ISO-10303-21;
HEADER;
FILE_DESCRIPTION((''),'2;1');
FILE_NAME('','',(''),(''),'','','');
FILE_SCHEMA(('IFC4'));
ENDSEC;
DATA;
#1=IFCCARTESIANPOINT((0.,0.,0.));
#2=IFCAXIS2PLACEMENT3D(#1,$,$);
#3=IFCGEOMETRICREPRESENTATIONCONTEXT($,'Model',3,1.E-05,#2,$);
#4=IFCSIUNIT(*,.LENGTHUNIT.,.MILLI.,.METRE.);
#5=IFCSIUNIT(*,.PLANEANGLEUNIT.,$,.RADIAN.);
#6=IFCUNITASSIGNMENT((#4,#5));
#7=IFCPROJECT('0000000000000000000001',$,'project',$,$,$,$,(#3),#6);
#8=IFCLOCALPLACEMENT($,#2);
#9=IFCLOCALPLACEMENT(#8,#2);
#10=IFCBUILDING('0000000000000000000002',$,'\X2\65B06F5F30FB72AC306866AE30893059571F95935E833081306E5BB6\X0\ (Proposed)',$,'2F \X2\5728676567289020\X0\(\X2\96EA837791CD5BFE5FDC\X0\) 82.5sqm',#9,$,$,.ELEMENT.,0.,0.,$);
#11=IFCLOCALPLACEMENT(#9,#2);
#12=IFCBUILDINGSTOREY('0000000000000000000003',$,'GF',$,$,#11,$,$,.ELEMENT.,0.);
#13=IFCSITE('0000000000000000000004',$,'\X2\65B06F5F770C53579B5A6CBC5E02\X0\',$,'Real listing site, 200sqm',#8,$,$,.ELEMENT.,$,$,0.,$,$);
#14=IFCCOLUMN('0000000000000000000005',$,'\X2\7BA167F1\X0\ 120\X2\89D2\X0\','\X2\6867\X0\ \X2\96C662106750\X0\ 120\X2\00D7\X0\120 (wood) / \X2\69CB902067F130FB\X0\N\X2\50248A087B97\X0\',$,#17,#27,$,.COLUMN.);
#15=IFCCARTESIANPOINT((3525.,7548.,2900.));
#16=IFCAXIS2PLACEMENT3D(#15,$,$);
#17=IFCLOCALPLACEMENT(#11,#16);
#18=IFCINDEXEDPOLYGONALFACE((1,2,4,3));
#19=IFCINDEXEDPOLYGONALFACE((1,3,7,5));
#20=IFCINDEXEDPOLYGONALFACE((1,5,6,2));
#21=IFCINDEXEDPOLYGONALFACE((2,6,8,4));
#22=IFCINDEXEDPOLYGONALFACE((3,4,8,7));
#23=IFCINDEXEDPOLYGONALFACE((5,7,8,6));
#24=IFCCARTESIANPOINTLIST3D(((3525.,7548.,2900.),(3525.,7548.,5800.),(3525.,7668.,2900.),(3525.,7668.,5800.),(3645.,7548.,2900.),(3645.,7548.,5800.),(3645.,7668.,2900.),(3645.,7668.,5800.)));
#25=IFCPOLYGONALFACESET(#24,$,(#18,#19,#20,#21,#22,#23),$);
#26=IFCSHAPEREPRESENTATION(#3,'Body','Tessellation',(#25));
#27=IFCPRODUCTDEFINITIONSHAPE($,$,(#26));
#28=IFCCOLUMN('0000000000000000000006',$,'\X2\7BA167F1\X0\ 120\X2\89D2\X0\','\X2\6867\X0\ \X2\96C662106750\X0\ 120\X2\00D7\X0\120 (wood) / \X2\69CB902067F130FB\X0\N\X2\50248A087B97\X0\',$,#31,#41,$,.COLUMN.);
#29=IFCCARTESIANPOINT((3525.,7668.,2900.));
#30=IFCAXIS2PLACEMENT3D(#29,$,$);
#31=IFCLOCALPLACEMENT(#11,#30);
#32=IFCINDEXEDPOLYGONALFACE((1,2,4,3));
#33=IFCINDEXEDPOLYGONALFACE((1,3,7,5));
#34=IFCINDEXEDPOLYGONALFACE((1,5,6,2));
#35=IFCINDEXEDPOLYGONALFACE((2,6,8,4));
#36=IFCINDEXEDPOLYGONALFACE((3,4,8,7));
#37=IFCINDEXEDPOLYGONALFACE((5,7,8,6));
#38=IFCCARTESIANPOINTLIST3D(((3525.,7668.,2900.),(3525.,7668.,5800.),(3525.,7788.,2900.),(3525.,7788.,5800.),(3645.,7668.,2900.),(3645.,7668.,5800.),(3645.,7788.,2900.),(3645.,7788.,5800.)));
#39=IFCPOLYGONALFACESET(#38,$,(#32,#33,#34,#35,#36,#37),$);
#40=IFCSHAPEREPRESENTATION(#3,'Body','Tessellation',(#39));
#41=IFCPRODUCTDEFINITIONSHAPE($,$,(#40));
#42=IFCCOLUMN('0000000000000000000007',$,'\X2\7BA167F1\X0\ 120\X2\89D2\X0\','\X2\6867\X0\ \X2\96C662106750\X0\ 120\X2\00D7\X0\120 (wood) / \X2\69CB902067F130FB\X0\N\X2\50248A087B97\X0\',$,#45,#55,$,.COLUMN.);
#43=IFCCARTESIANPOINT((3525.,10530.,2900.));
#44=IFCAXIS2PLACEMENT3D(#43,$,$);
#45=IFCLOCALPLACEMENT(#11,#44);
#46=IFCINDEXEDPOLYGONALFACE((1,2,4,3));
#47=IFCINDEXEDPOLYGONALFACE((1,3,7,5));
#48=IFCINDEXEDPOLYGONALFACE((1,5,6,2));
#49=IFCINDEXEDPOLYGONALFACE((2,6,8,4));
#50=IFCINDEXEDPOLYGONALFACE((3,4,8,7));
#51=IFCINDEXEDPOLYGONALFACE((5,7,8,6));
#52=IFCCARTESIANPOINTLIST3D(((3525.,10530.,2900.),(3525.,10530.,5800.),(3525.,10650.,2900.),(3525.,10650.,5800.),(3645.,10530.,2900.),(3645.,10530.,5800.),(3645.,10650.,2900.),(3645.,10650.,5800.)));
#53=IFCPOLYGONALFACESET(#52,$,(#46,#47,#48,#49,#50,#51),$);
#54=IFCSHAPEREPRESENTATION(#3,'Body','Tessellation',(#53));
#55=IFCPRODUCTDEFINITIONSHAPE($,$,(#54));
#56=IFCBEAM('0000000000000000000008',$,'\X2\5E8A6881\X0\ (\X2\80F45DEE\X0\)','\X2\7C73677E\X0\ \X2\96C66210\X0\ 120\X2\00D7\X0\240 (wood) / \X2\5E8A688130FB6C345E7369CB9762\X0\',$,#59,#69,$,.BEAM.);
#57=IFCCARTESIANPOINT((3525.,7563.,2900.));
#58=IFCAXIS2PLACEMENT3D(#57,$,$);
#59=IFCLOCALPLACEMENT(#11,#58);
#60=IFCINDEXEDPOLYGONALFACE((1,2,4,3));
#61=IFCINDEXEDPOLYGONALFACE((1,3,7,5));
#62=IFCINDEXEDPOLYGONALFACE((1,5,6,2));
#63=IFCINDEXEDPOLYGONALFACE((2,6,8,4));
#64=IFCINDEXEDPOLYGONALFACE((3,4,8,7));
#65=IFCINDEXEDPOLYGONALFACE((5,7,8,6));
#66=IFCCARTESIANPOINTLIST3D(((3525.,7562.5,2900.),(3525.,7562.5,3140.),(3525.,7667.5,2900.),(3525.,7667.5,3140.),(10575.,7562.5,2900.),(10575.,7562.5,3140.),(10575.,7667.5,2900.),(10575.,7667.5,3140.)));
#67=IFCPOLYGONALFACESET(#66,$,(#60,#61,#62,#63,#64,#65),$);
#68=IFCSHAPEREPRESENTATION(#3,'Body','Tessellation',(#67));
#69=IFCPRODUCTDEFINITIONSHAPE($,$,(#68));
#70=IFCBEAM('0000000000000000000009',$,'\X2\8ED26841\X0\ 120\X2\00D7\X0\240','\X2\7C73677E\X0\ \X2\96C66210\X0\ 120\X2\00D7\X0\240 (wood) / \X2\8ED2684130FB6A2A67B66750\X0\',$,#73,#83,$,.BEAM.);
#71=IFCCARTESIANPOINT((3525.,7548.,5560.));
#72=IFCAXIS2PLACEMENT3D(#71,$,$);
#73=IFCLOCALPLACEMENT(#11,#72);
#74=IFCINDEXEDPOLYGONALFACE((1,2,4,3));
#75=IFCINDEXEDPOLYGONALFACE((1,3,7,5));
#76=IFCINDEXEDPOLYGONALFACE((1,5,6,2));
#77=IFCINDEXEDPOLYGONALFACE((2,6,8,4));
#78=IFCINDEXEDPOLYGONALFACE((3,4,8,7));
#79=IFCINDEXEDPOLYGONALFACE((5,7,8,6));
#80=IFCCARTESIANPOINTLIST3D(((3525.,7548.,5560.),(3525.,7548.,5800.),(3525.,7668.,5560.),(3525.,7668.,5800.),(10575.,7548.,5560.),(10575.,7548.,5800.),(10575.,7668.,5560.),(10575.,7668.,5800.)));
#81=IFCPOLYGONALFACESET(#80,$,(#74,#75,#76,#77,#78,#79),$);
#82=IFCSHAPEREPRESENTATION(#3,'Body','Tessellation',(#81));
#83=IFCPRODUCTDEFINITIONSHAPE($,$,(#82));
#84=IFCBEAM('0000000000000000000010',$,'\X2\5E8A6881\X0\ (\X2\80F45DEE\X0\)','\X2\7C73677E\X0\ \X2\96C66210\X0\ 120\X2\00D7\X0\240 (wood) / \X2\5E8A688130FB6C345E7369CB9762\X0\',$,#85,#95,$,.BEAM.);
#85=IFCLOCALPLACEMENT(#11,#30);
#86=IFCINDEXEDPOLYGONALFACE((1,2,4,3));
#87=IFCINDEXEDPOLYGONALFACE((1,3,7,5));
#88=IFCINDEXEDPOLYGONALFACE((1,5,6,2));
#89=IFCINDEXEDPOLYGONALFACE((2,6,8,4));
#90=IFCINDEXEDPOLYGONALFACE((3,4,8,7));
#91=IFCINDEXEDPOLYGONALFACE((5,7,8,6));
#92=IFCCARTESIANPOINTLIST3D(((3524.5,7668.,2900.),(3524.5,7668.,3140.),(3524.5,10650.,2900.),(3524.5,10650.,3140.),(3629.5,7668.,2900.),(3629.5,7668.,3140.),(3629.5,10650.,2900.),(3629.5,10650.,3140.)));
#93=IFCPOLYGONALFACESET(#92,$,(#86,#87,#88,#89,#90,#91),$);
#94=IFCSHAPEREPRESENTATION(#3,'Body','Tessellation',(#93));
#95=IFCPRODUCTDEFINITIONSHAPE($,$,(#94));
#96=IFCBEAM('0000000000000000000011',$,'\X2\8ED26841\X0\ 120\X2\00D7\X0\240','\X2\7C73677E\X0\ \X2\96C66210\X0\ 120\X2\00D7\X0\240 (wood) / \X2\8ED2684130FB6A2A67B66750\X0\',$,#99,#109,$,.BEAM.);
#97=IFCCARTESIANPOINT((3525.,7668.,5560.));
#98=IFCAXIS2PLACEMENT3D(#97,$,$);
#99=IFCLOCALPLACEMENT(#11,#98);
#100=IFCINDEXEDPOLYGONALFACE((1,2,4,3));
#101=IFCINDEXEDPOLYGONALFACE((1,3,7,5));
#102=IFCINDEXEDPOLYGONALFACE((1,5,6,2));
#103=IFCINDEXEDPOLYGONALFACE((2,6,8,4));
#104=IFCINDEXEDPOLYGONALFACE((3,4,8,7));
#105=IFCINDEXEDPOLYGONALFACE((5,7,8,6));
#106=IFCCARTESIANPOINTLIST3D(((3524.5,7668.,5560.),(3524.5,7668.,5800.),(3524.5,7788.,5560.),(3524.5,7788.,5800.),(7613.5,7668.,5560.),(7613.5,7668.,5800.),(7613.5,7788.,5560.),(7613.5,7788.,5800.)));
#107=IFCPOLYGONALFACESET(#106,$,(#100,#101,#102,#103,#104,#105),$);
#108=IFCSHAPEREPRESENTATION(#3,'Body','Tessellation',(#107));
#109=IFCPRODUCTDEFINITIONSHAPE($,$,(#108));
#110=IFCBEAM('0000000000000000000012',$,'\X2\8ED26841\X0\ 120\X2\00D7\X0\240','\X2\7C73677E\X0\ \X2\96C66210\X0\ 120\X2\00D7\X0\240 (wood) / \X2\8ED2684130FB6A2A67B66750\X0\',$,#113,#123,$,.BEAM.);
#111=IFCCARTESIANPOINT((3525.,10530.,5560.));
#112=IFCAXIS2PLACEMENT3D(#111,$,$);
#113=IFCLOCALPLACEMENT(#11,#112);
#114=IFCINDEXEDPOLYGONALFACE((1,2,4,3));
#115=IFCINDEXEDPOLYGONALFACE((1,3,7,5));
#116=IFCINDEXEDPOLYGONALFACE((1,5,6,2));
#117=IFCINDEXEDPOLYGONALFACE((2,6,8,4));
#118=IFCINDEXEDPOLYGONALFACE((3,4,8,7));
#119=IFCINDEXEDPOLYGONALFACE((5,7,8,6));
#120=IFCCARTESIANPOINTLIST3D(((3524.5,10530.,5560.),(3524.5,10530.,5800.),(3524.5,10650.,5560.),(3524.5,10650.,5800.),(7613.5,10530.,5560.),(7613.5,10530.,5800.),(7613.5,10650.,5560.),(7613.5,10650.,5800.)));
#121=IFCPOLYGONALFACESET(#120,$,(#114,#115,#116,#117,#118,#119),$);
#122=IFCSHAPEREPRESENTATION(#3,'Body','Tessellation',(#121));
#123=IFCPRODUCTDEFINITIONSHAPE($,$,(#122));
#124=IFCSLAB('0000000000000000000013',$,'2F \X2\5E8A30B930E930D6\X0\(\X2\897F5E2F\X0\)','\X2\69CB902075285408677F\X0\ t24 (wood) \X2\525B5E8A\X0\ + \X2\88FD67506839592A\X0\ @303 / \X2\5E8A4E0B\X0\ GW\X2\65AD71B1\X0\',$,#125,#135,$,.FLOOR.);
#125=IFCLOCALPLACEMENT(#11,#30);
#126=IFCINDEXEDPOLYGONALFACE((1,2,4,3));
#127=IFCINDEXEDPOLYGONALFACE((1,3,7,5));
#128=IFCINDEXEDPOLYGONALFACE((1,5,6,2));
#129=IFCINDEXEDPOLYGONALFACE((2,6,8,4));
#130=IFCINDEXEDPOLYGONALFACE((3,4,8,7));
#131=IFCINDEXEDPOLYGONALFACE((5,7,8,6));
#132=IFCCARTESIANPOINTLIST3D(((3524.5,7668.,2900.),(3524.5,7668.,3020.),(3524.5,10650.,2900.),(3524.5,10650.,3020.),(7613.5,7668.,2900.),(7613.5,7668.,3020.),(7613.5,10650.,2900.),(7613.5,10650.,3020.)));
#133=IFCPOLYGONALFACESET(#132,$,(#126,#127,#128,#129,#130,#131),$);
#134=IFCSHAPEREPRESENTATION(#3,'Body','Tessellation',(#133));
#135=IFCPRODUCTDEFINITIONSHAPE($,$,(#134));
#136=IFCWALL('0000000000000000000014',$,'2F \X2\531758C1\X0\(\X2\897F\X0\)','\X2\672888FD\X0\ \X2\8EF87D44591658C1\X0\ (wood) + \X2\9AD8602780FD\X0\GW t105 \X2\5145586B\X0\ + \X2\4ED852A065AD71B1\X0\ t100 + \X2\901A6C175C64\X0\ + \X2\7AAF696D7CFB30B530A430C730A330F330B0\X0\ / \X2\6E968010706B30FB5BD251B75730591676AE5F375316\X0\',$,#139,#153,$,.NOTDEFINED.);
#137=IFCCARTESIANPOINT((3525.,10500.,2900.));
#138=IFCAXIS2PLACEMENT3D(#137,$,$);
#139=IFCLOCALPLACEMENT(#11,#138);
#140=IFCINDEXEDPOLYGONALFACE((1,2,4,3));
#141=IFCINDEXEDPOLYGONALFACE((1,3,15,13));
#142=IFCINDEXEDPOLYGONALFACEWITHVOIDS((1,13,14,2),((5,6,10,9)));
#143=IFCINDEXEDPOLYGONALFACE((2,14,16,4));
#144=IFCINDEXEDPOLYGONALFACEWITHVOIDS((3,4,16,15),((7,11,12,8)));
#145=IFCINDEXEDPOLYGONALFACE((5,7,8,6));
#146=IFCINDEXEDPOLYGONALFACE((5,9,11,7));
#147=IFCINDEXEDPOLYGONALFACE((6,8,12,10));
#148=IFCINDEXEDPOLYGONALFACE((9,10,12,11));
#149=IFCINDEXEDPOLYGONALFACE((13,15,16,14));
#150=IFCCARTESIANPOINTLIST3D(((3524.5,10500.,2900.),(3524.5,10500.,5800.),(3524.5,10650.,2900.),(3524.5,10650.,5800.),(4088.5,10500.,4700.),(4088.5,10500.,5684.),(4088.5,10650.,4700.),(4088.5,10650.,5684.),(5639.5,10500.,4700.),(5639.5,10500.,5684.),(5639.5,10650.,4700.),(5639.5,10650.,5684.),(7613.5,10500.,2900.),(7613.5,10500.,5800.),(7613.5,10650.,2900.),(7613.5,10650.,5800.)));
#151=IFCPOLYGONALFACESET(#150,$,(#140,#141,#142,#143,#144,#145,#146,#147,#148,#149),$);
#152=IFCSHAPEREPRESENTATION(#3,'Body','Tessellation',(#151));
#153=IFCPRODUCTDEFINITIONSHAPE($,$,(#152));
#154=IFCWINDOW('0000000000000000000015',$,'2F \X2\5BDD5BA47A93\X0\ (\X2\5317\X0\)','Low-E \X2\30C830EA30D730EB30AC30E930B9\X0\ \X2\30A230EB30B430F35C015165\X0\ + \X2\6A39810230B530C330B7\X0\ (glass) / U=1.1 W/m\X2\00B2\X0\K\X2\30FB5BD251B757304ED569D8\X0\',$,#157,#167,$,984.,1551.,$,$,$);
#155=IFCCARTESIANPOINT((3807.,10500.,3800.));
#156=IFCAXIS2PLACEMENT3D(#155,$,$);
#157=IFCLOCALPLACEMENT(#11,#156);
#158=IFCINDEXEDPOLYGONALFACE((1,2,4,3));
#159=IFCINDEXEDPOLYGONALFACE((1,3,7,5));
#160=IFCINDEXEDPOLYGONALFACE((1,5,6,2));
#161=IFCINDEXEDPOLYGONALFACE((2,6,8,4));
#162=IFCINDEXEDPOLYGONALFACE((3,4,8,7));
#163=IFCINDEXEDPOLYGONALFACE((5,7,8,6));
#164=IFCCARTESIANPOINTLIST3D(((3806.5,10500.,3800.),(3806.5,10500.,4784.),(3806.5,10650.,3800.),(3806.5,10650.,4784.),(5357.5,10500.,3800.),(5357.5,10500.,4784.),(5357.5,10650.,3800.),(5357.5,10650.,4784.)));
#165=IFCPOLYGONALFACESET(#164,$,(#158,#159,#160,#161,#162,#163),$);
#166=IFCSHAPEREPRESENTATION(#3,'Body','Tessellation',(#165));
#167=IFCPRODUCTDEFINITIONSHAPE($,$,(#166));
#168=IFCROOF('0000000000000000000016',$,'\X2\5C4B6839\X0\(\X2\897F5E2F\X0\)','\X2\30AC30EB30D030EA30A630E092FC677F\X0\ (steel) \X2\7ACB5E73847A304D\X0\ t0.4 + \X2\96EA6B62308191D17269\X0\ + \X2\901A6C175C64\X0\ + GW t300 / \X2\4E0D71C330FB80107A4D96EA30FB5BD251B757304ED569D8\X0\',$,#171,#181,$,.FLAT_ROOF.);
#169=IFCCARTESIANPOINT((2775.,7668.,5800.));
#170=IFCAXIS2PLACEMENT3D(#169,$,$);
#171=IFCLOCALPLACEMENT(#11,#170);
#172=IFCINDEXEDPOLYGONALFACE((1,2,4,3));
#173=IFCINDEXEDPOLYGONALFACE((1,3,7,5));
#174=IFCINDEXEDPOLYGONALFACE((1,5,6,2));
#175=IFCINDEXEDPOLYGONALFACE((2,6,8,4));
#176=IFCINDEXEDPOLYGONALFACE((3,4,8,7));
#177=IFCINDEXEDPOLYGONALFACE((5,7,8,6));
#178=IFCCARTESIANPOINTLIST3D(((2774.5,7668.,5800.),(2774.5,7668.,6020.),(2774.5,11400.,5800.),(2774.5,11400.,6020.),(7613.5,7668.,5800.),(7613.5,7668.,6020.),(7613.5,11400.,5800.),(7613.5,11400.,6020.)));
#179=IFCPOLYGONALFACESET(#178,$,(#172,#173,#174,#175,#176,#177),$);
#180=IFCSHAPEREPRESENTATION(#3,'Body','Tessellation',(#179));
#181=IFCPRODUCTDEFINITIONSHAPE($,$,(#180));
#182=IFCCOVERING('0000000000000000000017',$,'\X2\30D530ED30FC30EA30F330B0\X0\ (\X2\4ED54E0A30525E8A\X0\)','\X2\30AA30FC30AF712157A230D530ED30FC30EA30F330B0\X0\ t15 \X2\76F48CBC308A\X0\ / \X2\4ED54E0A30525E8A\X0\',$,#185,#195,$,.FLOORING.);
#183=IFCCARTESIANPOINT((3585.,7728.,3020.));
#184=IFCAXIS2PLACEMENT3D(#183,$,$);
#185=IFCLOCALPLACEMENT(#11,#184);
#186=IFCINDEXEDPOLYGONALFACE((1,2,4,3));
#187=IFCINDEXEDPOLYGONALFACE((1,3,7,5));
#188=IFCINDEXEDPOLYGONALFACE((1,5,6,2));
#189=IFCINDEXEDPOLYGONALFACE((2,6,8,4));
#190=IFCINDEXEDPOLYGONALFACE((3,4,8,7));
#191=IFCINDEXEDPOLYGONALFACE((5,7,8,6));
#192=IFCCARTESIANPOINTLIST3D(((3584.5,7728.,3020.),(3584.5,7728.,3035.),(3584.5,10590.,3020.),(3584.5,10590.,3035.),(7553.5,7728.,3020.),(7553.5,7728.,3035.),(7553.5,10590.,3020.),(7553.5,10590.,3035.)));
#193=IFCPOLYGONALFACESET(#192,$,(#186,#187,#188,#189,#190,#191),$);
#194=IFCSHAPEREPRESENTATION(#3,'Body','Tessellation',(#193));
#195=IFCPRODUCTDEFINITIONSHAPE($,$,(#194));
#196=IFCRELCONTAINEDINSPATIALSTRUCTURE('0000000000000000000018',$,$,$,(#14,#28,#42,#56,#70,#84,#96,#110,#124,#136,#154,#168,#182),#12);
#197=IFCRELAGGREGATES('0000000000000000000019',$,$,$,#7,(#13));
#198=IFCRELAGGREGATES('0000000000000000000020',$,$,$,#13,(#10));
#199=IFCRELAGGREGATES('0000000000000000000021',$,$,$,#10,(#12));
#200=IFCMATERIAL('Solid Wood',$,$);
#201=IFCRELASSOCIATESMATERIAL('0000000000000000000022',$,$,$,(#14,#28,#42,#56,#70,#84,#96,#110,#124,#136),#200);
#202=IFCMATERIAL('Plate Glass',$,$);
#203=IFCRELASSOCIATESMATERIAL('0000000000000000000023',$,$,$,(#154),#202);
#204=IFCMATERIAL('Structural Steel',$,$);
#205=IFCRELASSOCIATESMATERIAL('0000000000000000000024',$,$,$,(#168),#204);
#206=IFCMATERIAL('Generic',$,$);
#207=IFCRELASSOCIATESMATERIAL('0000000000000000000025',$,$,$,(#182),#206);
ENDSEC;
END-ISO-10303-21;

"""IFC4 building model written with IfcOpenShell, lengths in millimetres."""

from ifc_helpers import new_model, si_unit, frame, frame_2d, origin, place, context, project, spatial, rectangle, extrude, material, element, fill, save


model = new_model("IFC4")

# Units and contexts
model_context = context("Model", 3, precision=1e-05, world=origin())
ifc_project = project(units=[si_unit("LENGTHUNIT", "METRE", prefix="MILLI"), si_unit("PLANEANGLEUNIT", "RADIAN")], contexts=[model_context])

# Site, building, storey
site_placement = place(None, origin())
site = spatial("IfcSite", under=ifc_project, at=site_placement, Name="新潟県南魚沼市", ObjectType="Real listing site, 200sqm", CompositionType="ELEMENT", RefElevation=0.0)
building_placement = place(site_placement, origin())
building = spatial("IfcBuilding", under=site, at=building_placement, Name="新潟・犬と暮らす土間広めの家 (Proposed)", ObjectType="2F 在来木造(雪荷重対応) 82.5sqm", CompositionType="ELEMENT", ElevationOfRefHeight=0.0, ElevationOfTerrain=0.0)
storey_placement = place(building_placement, origin())
storey = spatial("IfcBuildingStorey", under=building, at=storey_placement, Name="GF", CompositionType="ELEMENT", Elevation=0.0)

# Columns
ifc_material_1 = material(Name="Solid Wood")
column_1_placement = place(storey_placement, frame((3525.0, 7548.0, 2900.0)))
element("IfcColumn", 1, at=column_1_placement, inside=storey, material=ifc_material_1, Name="管柱 120角", Description="桧 集成材 120×120 (wood) / 構造柱・N値計算", PredefinedType="COLUMN", context=model_context, shape_type="SweptSolid", body=[
    extrude(rectangle(XDim=120.0, YDim=120.0, at=frame_2d((60.0, 60.0))), frame((3525.0, 7548.0, 2900.0)), (0.0, 0.0, 1.0), 2900.0),
])
column_2_placement = place(storey_placement, frame((3525.0, 7668.0, 2900.0)))
element("IfcColumn", 2, at=column_2_placement, inside=storey, material=ifc_material_1, Name="管柱 120角", Description="桧 集成材 120×120 (wood) / 構造柱・N値計算", PredefinedType="COLUMN", context=model_context, shape_type="SweptSolid", body=[
    extrude(rectangle(XDim=120.0, YDim=120.0, at=frame_2d((60.0, 60.0))), frame((3525.0, 7668.0, 2900.0)), (0.0, 0.0, 1.0), 2900.0),
])
column_3_placement = place(storey_placement, frame((3525.0, 10530.0, 2900.0)))
element("IfcColumn", 3, at=column_3_placement, inside=storey, material=ifc_material_1, Name="管柱 120角", Description="桧 集成材 120×120 (wood) / 構造柱・N値計算", PredefinedType="COLUMN", context=model_context, shape_type="SweptSolid", body=[
    extrude(rectangle(XDim=120.0, YDim=120.0, at=frame_2d((60.0, 60.0))), frame((3525.0, 10530.0, 2900.0)), (0.0, 0.0, 1.0), 2900.0),
])

# Beams
beam_1_placement = place(storey_placement, frame((3525.0, 7563.0, 2900.0)))
element("IfcBeam", 4, at=beam_1_placement, inside=storey, material=ifc_material_1, Name="床梁 (胴差)", Description="米松 集成 120×240 (wood) / 床梁・水平構面", PredefinedType="BEAM", context=model_context, shape_type="SweptSolid", body=[
    extrude(rectangle(XDim=7050.0, YDim=105.0, at=frame_2d((3525.0, 52.0))), frame((3525.0, 7563.0, 2900.0)), (0.0, 0.0, 1.0), 240.0),
])
beam_2_placement = place(storey_placement, frame((3525.0, 7548.0, 5560.0)))
element("IfcBeam", 5, at=beam_2_placement, inside=storey, material=ifc_material_1, Name="軒桁 120×240", Description="米松 集成 120×240 (wood) / 軒桁・横架材", PredefinedType="BEAM", context=model_context, shape_type="SweptSolid", body=[
    extrude(rectangle(XDim=7050.0, YDim=120.0, at=frame_2d((3525.0, 60.0))), frame((3525.0, 7548.0, 5560.0)), (0.0, 0.0, 1.0), 240.0),
])
beam_3_placement = place(storey_placement, frame((3525.0, 7668.0, 2900.0)))
element("IfcBeam", 6, at=beam_3_placement, inside=storey, material=ifc_material_1, Name="床梁 (胴差)", Description="米松 集成 120×240 (wood) / 床梁・水平構面", PredefinedType="BEAM", context=model_context, shape_type="SweptSolid", body=[
    extrude(rectangle(XDim=105.0, YDim=2982.0, at=frame_2d((52.0, 1491.0))), frame((3525.0, 7668.0, 2900.0)), (0.0, 0.0, 1.0), 240.0),
])
beam_4_placement = place(storey_placement, frame((3525.0, 7668.0, 5560.0)))
element("IfcBeam", 7, at=beam_4_placement, inside=storey, material=ifc_material_1, Name="軒桁 120×240", Description="米松 集成 120×240 (wood) / 軒桁・横架材", PredefinedType="BEAM", context=model_context, shape_type="SweptSolid", body=[
    extrude(rectangle(XDim=4089.0, YDim=120.0, at=frame_2d((2044.0, 60.0))), frame((3525.0, 7668.0, 5560.0)), (0.0, 0.0, 1.0), 240.0),
])
beam_5_placement = place(storey_placement, frame((3525.0, 10530.0, 5560.0)))
element("IfcBeam", 8, at=beam_5_placement, inside=storey, material=ifc_material_1, Name="軒桁 120×240", Description="米松 集成 120×240 (wood) / 軒桁・横架材", PredefinedType="BEAM", context=model_context, shape_type="SweptSolid", body=[
    extrude(rectangle(XDim=4089.0, YDim=120.0, at=frame_2d((2044.0, 60.0))), frame((3525.0, 10530.0, 5560.0)), (0.0, 0.0, 1.0), 240.0),
])

# Slab
slab_placement = place(storey_placement, frame((3525.0, 7668.0, 2900.0)))
element("IfcSlab", 9, at=slab_placement, inside=storey, material=ifc_material_1, Name="2F 床スラブ(西帯)", Description="構造用合板 t24 (wood) 剛床 + 製材根太 @303 / 床下 GW断熱", PredefinedType="FLOOR", context=model_context, shape_type="SweptSolid", body=[
    extrude(rectangle(XDim=4089.0, YDim=2982.0, at=frame_2d((2044.0, 1491.0))), frame((3525.0, 7668.0, 2900.0)), (0.0, 0.0, 1.0), 120.0),
])

# Wall, opening, window
wall_1_placement = place(storey_placement, frame((3525.0, 10500.0, 2900.0)))
wall_1 = element("IfcWall", 10, at=wall_1_placement, inside=storey, material=ifc_material_1, Name="2F 北壁(西)", Description="木製 軸組外壁 (wood) + 高性能GW t105 充填 + 付加断熱 t100 + 通気層 + 窯業系サイディング / 準耐火・寒冷地外皮強化", PredefinedType="NOTDEFINED", context=model_context, shape_type="SweptSolid", body=[
    extrude(rectangle(XDim=4089.0, YDim=150.0, at=frame_2d((2044.0, 75.0))), frame((3525.0, 10500.0, 2900.0)), (0.0, 0.0, 1.0), 2900.0),
])
opening_placement = place(storey_placement, frame((3807.0, 10500.0, 3800.0)))
opening = element("IfcOpeningElement", 11, at=opening_placement, cuts=wall_1, PredefinedType="NOTDEFINED", context=model_context, shape_type="SweptSolid", body=[
    extrude(rectangle(XDim=1551.0, YDim=150.0, at=frame_2d((775.0, 75.0))), frame((3807.0, 10500.0, 3800.0)), (0.0, 0.0, 1.0), 984.0),
])
ifc_material_2 = material(Name="Plate Glass")
window_placement = place(storey_placement, frame((3807.0, 10500.0, 3800.0)))
window = element("IfcWindow", 12, at=window_placement, inside=storey, material=ifc_material_2, Name="2F 寝室窓 (北)", Description="Low-E トリプルガラス アルゴン封入 + 樹脂サッシ (glass) / U=1.1 W/m²K・寒冷地仕様", OverallHeight=984.0, OverallWidth=1551.0, context=model_context, shape_type="SweptSolid", body=[
    extrude(rectangle(XDim=1551.0, YDim=150.0, at=frame_2d((775.0, 75.0))), frame((3807.0, 10500.0, 3800.0)), (0.0, 0.0, 1.0), 984.0),
])
fill(opening, window)

# Roof
ifc_material_3 = material(Name="Structural Steel")
for number, where, name in (
    (13, (2775.0, 7668.0, 5800.0), "屋根(西帯)"),
):
    element("IfcRoof", number, at=place(storey_placement, frame(where)), inside=storey, material=ifc_material_3, Name=name, Description="ガルバリウム鋼板 (steel) 立平葺き t0.4 + 雪止め金物 + 通気層 + GW t300 / 不燃・耐積雪・寒冷地仕様", PredefinedType="FLAT_ROOF", context=model_context, shape_type="SweptSolid", body=[
        extrude(rectangle(XDim=4839.0, YDim=3732.0, at=frame_2d((2419.0, 1866.0))), frame((2775.0, 7668.0, 5800.0)), (0.0, 0.0, 1.0), 220.0),
    ])

# Covering
ifc_material_4 = material(Name="Generic")
covering_placement = place(storey_placement, frame((3585.0, 7728.0, 3020.0)))
element("IfcCovering", 14, at=covering_placement, inside=storey, material=ifc_material_4, Name="フローリング (仕上げ床)", Description="オーク無垢フローリング t15 直貼り / 仕上げ床", PredefinedType="FLOORING", context=model_context, shape_type="SweptSolid", body=[
    extrude(rectangle(XDim=3969.0, YDim=2862.0, at=frame_2d((1984.0, 1431.0))), frame((3585.0, 7728.0, 3020.0)), (0.0, 0.0, 1.0), 15.0),
])

save(model, "model.ifc")
